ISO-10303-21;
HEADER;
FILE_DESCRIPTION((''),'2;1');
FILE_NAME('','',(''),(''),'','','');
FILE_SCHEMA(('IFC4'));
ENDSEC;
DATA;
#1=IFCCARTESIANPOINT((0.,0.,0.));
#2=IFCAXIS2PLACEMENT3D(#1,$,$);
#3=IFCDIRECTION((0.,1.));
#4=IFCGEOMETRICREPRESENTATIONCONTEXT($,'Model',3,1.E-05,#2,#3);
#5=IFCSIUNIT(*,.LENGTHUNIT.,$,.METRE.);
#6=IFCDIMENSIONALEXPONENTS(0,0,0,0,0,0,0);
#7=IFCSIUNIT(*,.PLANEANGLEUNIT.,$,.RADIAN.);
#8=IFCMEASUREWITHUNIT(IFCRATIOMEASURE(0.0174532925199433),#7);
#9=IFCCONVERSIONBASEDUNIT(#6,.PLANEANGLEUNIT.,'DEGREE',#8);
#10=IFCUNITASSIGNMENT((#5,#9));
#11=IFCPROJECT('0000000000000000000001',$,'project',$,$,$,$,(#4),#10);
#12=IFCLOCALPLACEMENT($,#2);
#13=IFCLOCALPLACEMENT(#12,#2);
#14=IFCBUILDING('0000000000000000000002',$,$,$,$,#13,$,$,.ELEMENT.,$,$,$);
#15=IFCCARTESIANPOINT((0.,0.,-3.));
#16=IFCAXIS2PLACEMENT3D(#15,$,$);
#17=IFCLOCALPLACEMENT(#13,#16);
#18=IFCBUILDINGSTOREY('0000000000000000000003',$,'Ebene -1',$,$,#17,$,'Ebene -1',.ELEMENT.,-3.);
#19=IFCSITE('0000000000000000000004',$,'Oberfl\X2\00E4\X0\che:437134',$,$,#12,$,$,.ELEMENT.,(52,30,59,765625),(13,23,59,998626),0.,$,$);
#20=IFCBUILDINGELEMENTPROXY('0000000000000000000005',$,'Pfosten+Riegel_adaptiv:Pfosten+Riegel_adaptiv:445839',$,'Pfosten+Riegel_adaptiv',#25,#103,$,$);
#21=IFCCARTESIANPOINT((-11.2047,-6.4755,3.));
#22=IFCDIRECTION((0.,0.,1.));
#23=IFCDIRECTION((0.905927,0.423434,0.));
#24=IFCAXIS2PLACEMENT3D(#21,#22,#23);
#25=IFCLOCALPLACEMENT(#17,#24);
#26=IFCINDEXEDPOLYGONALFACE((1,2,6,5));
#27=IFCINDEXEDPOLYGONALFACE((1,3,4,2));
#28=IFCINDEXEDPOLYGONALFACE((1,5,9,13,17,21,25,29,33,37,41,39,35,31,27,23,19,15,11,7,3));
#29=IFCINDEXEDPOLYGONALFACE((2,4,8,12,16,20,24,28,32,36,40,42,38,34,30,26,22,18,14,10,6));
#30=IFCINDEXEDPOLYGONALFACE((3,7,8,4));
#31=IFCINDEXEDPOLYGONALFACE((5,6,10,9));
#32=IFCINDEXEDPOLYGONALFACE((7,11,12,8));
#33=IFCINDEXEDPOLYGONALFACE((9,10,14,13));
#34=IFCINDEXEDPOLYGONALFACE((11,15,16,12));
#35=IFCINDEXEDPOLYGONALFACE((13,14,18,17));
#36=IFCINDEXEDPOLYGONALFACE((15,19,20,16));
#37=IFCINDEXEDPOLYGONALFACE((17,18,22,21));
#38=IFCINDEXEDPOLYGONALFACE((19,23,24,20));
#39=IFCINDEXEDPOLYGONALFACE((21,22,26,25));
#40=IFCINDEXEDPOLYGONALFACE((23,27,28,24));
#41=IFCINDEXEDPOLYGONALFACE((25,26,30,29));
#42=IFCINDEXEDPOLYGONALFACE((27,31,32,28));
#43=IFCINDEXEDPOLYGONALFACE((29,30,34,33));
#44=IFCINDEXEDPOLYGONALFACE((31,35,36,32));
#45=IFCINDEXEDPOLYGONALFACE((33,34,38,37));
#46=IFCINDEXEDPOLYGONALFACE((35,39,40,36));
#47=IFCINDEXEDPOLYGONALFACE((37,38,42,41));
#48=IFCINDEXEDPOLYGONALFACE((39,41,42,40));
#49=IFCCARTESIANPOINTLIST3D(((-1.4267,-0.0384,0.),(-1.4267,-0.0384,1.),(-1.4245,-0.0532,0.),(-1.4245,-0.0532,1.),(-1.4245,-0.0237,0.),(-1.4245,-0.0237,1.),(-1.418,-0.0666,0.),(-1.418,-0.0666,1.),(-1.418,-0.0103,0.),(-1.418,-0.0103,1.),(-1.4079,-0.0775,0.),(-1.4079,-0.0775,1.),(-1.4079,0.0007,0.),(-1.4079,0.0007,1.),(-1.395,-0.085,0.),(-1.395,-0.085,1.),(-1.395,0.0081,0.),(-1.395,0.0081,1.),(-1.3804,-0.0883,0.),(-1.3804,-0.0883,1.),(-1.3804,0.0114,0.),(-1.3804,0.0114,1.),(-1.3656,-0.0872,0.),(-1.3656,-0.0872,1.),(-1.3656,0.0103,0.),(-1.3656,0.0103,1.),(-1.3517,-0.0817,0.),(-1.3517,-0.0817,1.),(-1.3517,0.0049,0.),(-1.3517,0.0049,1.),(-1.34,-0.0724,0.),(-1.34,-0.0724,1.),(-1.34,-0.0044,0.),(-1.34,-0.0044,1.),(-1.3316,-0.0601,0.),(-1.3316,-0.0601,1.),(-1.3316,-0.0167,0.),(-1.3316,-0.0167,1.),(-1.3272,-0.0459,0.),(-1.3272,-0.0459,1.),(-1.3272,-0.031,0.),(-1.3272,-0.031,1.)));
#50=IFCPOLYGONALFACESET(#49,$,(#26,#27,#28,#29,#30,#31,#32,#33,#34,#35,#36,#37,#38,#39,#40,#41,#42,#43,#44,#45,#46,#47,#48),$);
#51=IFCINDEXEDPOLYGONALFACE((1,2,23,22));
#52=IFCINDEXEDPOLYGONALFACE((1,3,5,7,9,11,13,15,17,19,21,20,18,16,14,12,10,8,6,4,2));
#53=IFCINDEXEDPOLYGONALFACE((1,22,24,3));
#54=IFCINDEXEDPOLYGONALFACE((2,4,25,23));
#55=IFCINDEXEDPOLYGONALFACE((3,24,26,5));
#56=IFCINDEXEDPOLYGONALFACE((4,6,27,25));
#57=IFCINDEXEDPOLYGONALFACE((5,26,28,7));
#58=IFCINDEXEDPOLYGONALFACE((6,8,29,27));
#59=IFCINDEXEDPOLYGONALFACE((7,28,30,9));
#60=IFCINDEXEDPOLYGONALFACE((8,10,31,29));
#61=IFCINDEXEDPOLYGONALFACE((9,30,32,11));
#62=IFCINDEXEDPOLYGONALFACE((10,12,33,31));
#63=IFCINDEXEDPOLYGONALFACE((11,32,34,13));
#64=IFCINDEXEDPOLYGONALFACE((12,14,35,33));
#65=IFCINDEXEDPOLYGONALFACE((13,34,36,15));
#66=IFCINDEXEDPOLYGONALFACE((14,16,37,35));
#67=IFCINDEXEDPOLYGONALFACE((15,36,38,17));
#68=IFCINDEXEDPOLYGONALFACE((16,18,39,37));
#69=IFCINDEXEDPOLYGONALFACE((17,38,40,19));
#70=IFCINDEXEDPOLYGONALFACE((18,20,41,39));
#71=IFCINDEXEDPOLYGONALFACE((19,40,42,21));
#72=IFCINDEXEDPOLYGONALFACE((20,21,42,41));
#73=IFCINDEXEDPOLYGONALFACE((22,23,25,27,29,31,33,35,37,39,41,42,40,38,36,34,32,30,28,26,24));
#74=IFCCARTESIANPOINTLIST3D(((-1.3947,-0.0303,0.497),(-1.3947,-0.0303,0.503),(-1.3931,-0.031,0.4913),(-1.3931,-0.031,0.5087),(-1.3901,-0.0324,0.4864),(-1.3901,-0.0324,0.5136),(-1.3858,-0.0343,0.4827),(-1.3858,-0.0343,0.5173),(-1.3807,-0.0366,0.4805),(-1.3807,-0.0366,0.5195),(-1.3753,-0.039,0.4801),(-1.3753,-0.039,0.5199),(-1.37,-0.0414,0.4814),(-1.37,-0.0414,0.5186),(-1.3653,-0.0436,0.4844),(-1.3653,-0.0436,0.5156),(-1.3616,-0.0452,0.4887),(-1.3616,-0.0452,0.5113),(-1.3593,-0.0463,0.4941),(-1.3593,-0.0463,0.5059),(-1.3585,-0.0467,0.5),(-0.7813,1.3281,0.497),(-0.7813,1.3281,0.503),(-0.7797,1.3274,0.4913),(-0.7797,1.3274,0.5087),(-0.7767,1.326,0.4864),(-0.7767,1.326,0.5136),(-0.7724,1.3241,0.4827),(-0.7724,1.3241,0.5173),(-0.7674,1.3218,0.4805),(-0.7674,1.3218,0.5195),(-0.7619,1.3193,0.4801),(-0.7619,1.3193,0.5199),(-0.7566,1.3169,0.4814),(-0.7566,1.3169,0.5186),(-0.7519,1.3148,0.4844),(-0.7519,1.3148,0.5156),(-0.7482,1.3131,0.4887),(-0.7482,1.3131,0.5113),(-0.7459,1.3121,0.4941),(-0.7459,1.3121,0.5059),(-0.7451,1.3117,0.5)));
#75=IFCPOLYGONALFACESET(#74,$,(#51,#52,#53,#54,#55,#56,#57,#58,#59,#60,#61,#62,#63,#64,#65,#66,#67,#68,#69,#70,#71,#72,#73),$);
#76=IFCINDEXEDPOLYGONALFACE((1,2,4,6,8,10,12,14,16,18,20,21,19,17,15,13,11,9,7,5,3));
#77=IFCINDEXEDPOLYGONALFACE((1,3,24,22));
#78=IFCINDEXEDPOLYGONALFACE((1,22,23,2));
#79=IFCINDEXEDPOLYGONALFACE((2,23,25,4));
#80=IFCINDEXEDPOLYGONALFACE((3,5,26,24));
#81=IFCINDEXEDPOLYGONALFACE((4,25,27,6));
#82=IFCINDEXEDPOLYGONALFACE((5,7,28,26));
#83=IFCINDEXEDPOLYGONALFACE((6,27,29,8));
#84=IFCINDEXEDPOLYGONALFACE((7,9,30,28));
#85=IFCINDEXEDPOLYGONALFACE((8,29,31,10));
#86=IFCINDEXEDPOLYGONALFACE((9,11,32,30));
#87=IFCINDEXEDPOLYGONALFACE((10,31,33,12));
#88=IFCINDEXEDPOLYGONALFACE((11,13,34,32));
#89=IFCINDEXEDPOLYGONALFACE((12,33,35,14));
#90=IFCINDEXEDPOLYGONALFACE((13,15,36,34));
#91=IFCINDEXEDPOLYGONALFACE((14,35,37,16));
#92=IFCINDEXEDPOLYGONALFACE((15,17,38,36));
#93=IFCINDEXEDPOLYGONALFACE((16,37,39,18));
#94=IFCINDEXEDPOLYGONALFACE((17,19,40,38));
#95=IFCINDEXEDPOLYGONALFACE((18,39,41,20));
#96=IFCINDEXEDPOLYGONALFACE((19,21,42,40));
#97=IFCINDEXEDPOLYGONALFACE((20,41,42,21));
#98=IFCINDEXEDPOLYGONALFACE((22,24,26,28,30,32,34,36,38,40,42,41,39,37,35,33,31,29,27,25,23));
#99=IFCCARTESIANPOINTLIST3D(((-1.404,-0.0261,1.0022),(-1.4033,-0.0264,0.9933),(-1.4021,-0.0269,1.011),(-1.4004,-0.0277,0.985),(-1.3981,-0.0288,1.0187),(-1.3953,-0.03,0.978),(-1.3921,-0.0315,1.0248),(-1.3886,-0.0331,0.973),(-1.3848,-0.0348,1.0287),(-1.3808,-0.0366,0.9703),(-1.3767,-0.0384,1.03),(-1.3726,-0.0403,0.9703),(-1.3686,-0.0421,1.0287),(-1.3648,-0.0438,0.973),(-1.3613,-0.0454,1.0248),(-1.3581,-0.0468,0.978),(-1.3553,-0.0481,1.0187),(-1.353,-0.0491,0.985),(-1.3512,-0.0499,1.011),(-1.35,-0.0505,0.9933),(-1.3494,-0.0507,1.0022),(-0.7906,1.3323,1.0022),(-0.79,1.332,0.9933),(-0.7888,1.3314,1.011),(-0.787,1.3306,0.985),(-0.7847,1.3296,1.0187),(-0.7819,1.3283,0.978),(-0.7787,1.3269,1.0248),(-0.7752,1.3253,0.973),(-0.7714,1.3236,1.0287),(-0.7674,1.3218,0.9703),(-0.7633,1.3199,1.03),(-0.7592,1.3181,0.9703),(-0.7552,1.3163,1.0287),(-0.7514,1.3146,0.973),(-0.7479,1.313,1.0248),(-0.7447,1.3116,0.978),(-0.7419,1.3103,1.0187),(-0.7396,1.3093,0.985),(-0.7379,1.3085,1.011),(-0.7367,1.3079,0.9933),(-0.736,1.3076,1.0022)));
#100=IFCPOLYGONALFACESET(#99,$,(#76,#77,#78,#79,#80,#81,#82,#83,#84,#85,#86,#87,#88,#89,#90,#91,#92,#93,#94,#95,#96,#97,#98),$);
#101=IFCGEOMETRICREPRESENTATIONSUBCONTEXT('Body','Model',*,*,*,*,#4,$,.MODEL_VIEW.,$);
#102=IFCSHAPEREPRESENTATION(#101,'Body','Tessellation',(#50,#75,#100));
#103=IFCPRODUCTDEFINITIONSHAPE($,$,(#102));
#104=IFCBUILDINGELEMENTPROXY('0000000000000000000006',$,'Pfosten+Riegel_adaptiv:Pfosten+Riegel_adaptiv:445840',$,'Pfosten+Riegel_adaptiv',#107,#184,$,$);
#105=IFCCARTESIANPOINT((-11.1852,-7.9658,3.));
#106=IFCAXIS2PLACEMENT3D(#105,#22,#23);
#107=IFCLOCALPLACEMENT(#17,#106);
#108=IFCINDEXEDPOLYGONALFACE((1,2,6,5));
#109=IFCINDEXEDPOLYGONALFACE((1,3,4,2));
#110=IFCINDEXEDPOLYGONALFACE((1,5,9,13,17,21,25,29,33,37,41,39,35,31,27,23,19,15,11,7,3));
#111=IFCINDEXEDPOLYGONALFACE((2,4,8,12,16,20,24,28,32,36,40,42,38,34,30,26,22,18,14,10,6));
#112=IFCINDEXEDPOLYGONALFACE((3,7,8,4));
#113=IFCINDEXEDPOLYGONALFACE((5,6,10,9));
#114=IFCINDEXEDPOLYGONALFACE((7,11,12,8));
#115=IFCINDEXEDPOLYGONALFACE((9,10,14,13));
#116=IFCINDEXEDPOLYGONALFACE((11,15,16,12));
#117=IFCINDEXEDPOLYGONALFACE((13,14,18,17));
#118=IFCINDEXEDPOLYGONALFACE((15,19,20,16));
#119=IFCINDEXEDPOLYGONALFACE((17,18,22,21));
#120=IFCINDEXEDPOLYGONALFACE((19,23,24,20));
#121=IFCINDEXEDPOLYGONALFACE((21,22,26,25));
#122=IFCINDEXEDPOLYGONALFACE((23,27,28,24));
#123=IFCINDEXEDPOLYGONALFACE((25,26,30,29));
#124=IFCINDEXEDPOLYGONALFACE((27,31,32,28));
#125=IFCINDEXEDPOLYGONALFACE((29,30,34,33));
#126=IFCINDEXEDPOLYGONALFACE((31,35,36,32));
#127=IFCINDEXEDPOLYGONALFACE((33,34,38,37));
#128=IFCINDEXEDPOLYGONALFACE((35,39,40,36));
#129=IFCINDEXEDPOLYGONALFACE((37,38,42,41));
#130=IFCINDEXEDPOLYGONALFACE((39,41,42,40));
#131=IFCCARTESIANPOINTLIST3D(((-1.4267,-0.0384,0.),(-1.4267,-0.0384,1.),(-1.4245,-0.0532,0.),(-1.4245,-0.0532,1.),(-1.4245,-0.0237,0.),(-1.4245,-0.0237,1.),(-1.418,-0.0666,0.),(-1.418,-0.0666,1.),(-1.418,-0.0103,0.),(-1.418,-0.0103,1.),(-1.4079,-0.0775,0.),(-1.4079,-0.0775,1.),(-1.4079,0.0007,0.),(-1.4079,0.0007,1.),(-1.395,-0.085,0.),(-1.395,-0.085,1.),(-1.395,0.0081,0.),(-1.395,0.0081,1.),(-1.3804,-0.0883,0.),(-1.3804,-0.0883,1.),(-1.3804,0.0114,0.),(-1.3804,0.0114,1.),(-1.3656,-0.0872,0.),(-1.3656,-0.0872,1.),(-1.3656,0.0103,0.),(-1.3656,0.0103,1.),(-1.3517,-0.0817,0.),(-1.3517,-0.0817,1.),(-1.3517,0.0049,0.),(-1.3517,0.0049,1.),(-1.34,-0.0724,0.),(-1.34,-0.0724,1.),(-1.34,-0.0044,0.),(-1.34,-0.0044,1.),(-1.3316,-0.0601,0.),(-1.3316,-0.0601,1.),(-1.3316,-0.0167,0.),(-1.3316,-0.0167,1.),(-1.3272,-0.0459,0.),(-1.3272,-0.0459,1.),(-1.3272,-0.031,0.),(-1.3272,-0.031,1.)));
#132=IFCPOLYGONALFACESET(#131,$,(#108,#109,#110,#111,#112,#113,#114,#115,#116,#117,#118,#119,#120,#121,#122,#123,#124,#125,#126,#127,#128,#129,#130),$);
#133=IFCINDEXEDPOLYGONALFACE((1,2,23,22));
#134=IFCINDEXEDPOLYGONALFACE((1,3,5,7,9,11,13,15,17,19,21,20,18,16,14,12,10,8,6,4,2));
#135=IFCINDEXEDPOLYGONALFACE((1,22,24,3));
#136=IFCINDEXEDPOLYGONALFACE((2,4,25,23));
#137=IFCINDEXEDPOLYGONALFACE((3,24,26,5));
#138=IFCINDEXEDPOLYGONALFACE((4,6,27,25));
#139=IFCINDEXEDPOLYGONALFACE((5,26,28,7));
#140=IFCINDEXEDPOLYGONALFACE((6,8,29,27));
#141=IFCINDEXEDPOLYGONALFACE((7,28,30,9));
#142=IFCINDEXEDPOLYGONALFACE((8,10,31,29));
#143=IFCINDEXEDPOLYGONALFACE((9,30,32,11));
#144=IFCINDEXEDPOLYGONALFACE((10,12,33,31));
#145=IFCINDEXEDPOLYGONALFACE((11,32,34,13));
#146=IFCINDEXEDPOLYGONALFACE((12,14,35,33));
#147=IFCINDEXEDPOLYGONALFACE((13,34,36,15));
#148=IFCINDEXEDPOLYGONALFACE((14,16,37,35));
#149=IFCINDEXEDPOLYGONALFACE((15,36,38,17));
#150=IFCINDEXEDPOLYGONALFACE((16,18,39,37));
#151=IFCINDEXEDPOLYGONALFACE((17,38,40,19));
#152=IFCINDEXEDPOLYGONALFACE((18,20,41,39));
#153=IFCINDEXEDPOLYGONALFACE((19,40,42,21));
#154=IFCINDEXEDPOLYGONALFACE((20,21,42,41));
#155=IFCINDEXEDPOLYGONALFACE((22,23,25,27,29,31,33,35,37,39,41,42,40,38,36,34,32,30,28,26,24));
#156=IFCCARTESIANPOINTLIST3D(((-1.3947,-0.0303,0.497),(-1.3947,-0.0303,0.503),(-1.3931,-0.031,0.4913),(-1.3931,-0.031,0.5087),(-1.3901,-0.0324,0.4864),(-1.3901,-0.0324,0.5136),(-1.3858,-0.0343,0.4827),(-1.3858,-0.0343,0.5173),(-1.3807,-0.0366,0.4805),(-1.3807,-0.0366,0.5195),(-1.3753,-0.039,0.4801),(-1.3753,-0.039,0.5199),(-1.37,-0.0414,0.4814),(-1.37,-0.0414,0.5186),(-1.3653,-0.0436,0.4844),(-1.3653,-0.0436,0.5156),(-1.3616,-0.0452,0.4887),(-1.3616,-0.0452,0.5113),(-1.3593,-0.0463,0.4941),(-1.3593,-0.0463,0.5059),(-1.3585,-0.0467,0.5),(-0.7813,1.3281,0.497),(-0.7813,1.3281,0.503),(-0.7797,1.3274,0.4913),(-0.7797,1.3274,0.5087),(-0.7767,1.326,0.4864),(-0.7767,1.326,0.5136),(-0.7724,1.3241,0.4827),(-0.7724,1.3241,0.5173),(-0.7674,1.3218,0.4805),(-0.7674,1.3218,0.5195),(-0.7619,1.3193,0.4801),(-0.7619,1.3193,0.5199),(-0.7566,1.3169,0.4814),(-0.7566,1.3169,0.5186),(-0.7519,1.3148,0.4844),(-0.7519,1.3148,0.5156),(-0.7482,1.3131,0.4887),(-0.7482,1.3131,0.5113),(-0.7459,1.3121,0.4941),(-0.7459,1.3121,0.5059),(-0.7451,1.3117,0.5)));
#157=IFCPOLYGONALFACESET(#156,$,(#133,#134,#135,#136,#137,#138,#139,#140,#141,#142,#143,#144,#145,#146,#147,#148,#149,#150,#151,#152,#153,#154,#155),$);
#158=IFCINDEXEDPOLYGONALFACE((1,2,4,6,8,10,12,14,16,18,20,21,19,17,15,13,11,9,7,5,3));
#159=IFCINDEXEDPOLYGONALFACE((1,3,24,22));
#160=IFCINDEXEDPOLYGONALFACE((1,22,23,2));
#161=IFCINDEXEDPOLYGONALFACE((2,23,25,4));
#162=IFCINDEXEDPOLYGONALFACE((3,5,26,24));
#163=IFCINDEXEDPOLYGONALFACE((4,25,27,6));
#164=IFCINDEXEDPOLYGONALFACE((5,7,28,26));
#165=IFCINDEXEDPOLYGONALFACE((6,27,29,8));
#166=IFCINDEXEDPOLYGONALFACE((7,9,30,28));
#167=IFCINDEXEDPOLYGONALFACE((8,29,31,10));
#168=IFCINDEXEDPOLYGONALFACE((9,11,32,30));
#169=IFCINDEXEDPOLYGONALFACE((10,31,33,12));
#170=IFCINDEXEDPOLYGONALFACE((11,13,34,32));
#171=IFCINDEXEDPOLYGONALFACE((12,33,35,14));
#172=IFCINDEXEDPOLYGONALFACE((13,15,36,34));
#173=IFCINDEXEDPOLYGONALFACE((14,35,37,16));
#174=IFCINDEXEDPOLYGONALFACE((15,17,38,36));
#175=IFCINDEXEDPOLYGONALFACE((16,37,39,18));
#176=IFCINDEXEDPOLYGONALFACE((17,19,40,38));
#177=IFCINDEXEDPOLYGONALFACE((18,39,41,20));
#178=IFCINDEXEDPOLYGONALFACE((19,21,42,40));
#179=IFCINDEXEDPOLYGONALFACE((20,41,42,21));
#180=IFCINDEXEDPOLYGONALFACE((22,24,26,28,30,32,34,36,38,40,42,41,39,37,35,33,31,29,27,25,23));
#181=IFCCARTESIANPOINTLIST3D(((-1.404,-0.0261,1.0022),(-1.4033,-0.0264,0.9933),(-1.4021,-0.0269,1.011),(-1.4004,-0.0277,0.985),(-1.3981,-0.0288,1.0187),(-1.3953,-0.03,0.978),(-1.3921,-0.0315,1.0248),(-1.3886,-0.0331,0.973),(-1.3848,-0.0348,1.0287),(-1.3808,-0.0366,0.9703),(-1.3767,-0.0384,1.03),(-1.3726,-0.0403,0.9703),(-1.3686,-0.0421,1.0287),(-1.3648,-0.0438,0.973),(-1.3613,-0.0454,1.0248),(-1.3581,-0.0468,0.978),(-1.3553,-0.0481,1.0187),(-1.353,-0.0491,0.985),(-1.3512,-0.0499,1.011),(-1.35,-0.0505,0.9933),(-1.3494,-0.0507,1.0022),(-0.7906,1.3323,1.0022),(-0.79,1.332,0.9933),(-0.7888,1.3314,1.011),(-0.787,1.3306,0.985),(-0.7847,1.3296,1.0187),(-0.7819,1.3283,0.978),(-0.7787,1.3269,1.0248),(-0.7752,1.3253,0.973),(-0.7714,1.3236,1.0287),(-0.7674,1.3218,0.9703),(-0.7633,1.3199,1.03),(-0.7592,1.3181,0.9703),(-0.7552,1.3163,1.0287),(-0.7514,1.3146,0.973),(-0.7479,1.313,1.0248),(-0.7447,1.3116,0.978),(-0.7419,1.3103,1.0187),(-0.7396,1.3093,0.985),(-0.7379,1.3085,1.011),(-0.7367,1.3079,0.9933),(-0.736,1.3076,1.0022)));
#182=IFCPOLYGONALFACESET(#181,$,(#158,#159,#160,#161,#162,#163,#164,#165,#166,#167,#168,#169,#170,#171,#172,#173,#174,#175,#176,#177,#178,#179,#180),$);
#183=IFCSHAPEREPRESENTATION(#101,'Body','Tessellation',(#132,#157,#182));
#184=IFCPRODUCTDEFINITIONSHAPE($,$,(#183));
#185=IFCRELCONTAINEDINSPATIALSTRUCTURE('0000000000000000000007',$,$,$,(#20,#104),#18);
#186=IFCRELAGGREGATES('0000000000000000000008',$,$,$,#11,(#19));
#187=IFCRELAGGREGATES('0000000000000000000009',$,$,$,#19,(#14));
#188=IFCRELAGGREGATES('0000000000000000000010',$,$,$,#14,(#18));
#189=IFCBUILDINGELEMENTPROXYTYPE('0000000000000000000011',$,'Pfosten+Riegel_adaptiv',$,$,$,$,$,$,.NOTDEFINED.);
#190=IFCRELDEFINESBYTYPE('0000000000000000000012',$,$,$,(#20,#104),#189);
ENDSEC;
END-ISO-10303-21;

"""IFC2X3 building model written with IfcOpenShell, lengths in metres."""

from ifc_helpers import new_model, entity, si_unit, converted_unit, direction, frame, frame_2d, origin, place, context, subcontext, project, spatial, circle, extrude, source, transform, mapped, type_object, type_shapes, element, save


model = new_model("IFC2X3")

# Units and contexts
model_context = context("Model", 3, precision=1e-05, world=origin(), true_north=direction((0.0, 1.0)))
body_context = subcontext(model_context, "Body", "Model", "MODEL_VIEW")
ifc_project = project(units=[si_unit("LENGTHUNIT", "METRE"), converted_unit("PLANEANGLEUNIT", "DEGREE", entity("IfcRatioMeasure", 0.0174532925199433), si_unit("PLANEANGLEUNIT", "RADIAN"), dimensions=[0, 0, 0, 0, 0, 0, 0])], contexts=[model_context])

# Site, building, storey
site_placement = place(None, origin())
site = spatial("IfcSite", under=ifc_project, at=site_placement, Name="Oberfläche:437134", CompositionType="ELEMENT", RefLatitude=(52, 30, 59, 765625), RefLongitude=(13, 23, 59, 998626), RefElevation=0.0)
building_placement = place(site_placement, origin())
building = spatial("IfcBuilding", under=site, at=building_placement, CompositionType="ELEMENT")
storey_placement = place(building_placement, frame((0.0, 0.0, -3.0)))
storey = spatial("IfcBuildingStorey", under=building, at=storey_placement, Name="Ebene -1", LongName="Ebene -1", CompositionType="ELEMENT", Elevation=-3.0)

# Building element proxies
building_element_proxy_type_1 = type_object("IfcBuildingElementProxyType", Name="Pfosten+Riegel_adaptiv", PredefinedType="NOTDEFINED")
shared_shape_1 = source(origin(), body_context, "Body", "SweptSolid", [
    extrude(circle(Radius=0.05, at=frame_2d((0.0, 0.0), x_axis=(1.0, 0.0))), frame((-1.3767, -0.0384, 0.0), z_axis=(0.0, 0.0, 1.0), x_axis=(-1.0, 0.0, 0.0)), (0.0, 0.0, 1.0), 1.0),
    extrude(circle(Radius=0.02, at=frame_2d((0.0, 0.0), x_axis=(1.0, 0.0))), frame((-1.3767, -0.0384, 0.5), z_axis=(0.411546, 0.911389, 0.0), x_axis=(0.911389, -0.411546, 0.0)), (0.0, 0.0, 1.0), 1.4904),
    extrude(circle(Radius=0.03, at=frame_2d((0.0, 0.0), x_axis=(1.0, 0.0))), frame((-1.3767, -0.0384, 1.0), z_axis=(0.411546, 0.911389, 0.0), x_axis=(0.0, 0.0, 1.0)), (0.0, 0.0, 1.0), 1.4904),
])
type_shapes(building_element_proxy_type_1, [shared_shape_1])
for number, where, z_axis, x_axis, name in (
    (1, (-11.2047, -6.4755, 3.0), (0.0, 0.0, 1.0), (0.905927, 0.423434, 0.0), "Pfosten+Riegel_adaptiv:Pfosten+Riegel_adaptiv:445839"),
    (2, (-11.1852, -7.9658, 3.0), (0.0, 0.0, 1.0), (0.905927, 0.423434, 0.0), "Pfosten+Riegel_adaptiv:Pfosten+Riegel_adaptiv:445840"),
):
    element("IfcBuildingElementProxy", number, at=place(storey_placement, frame(where, z_axis=z_axis, x_axis=x_axis)), inside=storey, type_object=building_element_proxy_type_1, Name=name, ObjectType="Pfosten+Riegel_adaptiv", context=body_context, shape_type="MappedRepresentation", body=[
        mapped(shared_shape_1, transform((0.0, 0.0, 0.0), scale=1.0)),
    ])

save(model, "model.ifc")
